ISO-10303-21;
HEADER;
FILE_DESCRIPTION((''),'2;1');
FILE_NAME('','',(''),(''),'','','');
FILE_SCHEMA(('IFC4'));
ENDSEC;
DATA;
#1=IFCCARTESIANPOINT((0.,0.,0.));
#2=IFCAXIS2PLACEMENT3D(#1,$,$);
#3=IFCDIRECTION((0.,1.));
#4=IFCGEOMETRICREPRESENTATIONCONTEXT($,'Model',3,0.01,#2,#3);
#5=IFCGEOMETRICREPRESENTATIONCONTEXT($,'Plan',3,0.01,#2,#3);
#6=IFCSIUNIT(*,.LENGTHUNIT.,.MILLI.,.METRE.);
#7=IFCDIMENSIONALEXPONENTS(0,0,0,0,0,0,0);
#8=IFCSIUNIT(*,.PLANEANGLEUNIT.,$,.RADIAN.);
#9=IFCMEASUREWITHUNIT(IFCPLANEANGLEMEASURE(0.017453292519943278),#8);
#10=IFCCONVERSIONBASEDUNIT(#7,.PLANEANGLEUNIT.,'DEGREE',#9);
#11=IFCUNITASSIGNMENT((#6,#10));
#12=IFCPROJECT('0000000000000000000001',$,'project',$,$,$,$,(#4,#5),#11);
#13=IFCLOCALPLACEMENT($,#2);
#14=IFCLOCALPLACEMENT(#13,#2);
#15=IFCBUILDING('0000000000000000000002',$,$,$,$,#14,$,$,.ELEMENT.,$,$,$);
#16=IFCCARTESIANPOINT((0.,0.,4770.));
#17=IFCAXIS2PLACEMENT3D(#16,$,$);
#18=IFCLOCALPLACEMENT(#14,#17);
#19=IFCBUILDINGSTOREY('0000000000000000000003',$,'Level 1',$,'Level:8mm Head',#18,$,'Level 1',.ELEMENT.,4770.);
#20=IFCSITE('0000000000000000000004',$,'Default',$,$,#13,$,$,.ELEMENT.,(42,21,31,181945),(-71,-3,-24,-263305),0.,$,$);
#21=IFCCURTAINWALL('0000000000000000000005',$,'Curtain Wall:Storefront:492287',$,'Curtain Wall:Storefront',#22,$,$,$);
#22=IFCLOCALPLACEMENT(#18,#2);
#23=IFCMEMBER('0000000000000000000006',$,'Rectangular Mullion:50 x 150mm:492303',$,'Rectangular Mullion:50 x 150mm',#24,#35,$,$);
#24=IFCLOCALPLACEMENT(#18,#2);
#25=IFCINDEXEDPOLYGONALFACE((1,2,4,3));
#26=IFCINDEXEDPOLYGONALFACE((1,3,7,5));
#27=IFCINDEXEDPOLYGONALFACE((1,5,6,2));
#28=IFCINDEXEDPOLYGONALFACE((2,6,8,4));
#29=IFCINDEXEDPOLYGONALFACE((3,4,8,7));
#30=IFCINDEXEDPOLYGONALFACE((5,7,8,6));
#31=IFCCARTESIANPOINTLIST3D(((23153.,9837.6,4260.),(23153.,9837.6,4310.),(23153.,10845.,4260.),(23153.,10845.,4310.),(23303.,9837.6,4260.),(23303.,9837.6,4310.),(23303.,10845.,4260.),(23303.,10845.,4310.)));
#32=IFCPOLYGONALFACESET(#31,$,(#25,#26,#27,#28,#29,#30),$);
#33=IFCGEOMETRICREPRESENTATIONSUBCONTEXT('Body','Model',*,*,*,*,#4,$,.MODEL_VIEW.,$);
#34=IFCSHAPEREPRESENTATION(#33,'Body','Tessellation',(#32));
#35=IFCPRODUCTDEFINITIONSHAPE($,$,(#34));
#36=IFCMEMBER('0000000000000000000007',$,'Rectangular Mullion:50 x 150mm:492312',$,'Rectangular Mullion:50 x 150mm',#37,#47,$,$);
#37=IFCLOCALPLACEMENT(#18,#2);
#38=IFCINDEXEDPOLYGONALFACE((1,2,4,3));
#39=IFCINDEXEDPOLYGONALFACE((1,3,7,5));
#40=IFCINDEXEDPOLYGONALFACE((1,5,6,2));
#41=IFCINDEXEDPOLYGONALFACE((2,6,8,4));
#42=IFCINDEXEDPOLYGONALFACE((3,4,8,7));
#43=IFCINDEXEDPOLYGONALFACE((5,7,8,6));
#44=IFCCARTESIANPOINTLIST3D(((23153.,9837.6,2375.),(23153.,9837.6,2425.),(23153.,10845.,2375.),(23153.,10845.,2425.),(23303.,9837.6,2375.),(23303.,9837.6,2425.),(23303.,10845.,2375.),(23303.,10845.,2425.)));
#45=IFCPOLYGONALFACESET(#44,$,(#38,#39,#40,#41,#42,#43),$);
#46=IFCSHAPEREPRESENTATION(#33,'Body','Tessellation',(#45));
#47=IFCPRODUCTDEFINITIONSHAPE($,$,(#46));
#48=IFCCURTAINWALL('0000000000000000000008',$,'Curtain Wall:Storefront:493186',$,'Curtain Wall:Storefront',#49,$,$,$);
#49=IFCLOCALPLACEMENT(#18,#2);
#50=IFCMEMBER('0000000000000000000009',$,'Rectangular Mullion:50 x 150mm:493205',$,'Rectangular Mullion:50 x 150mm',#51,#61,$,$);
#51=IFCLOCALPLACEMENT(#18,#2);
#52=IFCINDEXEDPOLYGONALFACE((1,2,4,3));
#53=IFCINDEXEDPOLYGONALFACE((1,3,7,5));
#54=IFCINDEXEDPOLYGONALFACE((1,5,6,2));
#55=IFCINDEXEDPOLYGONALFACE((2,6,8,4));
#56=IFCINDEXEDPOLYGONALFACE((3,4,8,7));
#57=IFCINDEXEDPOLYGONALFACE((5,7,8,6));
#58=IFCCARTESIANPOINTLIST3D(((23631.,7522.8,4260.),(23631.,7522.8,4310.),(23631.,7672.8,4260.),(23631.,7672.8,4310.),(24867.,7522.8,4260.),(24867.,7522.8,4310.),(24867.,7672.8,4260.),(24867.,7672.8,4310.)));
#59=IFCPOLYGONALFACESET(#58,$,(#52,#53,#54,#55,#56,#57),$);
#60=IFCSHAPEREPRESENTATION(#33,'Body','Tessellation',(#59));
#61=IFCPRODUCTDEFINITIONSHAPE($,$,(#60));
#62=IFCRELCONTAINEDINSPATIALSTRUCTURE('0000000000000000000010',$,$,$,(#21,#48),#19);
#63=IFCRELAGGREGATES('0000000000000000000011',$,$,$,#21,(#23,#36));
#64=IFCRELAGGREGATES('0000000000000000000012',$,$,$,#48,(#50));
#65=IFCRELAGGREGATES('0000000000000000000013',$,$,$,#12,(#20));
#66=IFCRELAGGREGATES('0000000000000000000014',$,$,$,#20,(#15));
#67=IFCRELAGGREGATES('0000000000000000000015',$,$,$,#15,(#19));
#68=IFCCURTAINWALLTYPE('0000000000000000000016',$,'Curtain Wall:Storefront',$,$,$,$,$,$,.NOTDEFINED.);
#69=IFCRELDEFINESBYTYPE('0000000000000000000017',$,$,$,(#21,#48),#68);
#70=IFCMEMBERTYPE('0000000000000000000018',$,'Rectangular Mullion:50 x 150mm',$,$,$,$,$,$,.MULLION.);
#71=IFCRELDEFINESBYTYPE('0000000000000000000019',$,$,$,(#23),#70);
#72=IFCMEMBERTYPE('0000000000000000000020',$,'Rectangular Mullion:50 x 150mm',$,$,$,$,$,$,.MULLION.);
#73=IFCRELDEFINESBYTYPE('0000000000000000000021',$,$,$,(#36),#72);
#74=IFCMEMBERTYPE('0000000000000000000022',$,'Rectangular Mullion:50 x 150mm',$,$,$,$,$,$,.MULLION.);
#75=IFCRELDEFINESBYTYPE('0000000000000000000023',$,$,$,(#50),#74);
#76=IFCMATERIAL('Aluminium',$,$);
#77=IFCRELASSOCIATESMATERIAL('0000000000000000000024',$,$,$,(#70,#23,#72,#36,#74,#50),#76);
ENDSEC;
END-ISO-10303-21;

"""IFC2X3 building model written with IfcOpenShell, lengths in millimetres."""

from ifc_helpers import new_model, entity, si_unit, converted_unit, direction, frame, origin, origin_2d_with_axis, place, context, subcontext, project, spatial, rectangle, extrude, source, transform, mapped, material, type_object, type_shapes, element, aggregate, save


model = new_model("IFC2X3")

# Units and contexts
model_context = context("Model", 3, precision=0.01, world=origin(), true_north=direction((0.0, 1.0)))
plan_context = context("Plan", 3, precision=0.01, world=origin(), true_north=direction((0.0, 1.0)))
body_context = subcontext(model_context, "Body", "Model", "MODEL_VIEW")
ifc_project = project(units=[si_unit("LENGTHUNIT", "METRE", prefix="MILLI"), converted_unit("PLANEANGLEUNIT", "DEGREE", entity("IfcPlaneAngleMeasure", 0.017453292519943278), si_unit("PLANEANGLEUNIT", "RADIAN"), dimensions=[0, 0, 0, 0, 0, 0, 0])], contexts=[model_context, plan_context])

# Site, building, storey
site_placement = place(None, origin())
site = spatial("IfcSite", under=ifc_project, at=site_placement, Name="Default", CompositionType="ELEMENT", RefLatitude=(42, 21, 31, 181945), RefLongitude=(-71, -3, -24, -263305), RefElevation=0.0)
building_placement = place(site_placement, origin())
building = spatial("IfcBuilding", under=site, at=building_placement, CompositionType="ELEMENT")
storey_placement = place(building_placement, frame((0.0, 0.0, 4770.0)))
storey = spatial("IfcBuildingStorey", under=building, at=storey_placement, Name="Level 1", ObjectType="Level:8mm Head", LongName="Level 1", CompositionType="ELEMENT", Elevation=4770.0)

# Curtain wall
curtain_wall_type = type_object("IfcCurtainWallType", Name="Curtain Wall:Storefront", PredefinedType="NOTDEFINED")
curtain_wall_1_placement = place(storey_placement, frame((0.0, 0.0, -4770.0)))
curtain_wall_1 = element("IfcCurtainWall", 1, at=curtain_wall_1_placement, inside=storey, type_object=curtain_wall_type, Name="Curtain Wall:Storefront:492287", ObjectType="Curtain Wall:Storefront")
ifc_material_1 = material(Name="Aluminium")

# Members
member_type_1 = type_object("IfcMemberType", Name="Rectangular Mullion:50 x 150mm", PredefinedType="MULLION", material=ifc_material_1)
shared_shape_1 = source(origin(), body_context, "Body", "SweptSolid", [
    extrude(rectangle(XDim=50.0, YDim=150.0, at=origin_2d_with_axis()), frame((-25.0, 0.0, -1007.4), z_axis=(0.0, 0.0, 1.0), x_axis=(-1.0, 0.0, 0.0)), (0.0, 0.0, 1.0), 1007.4),
])
type_shapes(member_type_1, [shared_shape_1])
member_1_placement = place(curtain_wall_1_placement, frame((23228.0, 9837.6, 9080.0), z_axis=(0.0, -1.0, 0.0), x_axis=(0.0, 0.0, 1.0)))
member_1 = element("IfcMember", 2, at=member_1_placement, type_object=member_type_1, material=ifc_material_1, Name="Rectangular Mullion:50 x 150mm:492303", ObjectType="Rectangular Mullion:50 x 150mm", context=body_context, shape_type="MappedRepresentation", body=[
    mapped(shared_shape_1, transform((0.0, 0.0, 0.0), scale=1.0)),
])
member_type_2 = type_object("IfcMemberType", Name="Rectangular Mullion:50 x 150mm", PredefinedType="MULLION", material=ifc_material_1)
shared_shape_2 = source(origin(), body_context, "Body", "SweptSolid", [
    extrude(rectangle(XDim=50.0, YDim=150.0, at=origin_2d_with_axis()), frame((0.0, 0.0, -1007.4), z_axis=(0.0, 0.0, 1.0), x_axis=(-1.0, 0.0, 0.0)), (0.0, 0.0, 1.0), 1007.4),
])
type_shapes(member_type_2, [shared_shape_2])
member_2_placement = place(curtain_wall_1_placement, frame((23228.0, 9837.6, 7170.0), z_axis=(0.0, -1.0, 0.0), x_axis=(0.0, 0.0, 1.0)))
member_2 = element("IfcMember", 3, at=member_2_placement, type_object=member_type_2, material=ifc_material_1, Name="Rectangular Mullion:50 x 150mm:492312", ObjectType="Rectangular Mullion:50 x 150mm", context=body_context, shape_type="MappedRepresentation", body=[
    mapped(shared_shape_2, transform((0.0, 0.0, 0.0), scale=1.0)),
])

# Curtain wall, member
curtain_wall_2_placement = place(storey_placement, frame((0.0, 0.0, -4770.0)))
curtain_wall_2 = element("IfcCurtainWall", 4, at=curtain_wall_2_placement, inside=storey, type_object=curtain_wall_type, Name="Curtain Wall:Storefront:493186", ObjectType="Curtain Wall:Storefront")
member_type_3 = type_object("IfcMemberType", Name="Rectangular Mullion:50 x 150mm", PredefinedType="MULLION", material=ifc_material_1)
shared_shape_3 = source(origin(), body_context, "Body", "SweptSolid", [
    extrude(rectangle(XDim=50.0, YDim=150.0, at=origin_2d_with_axis()), frame((-25.0, 0.0, -1236.0), z_axis=(0.0, 0.0, 1.0), x_axis=(-1.0, 0.0, 0.0)), (0.0, 0.0, 1.0), 1236.0),
])
type_shapes(member_type_3, [shared_shape_3])
member_3_placement = place(curtain_wall_2_placement, frame((23631.0, 7597.8, 9080.0), z_axis=(-1.0, 0.0, 0.0), x_axis=(0.0, 0.0, 1.0)))
member_3 = element("IfcMember", 5, at=member_3_placement, type_object=member_type_3, material=ifc_material_1, Name="Rectangular Mullion:50 x 150mm:493205", ObjectType="Rectangular Mullion:50 x 150mm", context=body_context, shape_type="MappedRepresentation", body=[
    mapped(shared_shape_3, transform((0.0, 0.0, 0.0), scale=1.0)),
])

aggregate(curtain_wall_1, [member_1, member_2])
aggregate(curtain_wall_2, [member_3])

save(model, "model.ifc")
